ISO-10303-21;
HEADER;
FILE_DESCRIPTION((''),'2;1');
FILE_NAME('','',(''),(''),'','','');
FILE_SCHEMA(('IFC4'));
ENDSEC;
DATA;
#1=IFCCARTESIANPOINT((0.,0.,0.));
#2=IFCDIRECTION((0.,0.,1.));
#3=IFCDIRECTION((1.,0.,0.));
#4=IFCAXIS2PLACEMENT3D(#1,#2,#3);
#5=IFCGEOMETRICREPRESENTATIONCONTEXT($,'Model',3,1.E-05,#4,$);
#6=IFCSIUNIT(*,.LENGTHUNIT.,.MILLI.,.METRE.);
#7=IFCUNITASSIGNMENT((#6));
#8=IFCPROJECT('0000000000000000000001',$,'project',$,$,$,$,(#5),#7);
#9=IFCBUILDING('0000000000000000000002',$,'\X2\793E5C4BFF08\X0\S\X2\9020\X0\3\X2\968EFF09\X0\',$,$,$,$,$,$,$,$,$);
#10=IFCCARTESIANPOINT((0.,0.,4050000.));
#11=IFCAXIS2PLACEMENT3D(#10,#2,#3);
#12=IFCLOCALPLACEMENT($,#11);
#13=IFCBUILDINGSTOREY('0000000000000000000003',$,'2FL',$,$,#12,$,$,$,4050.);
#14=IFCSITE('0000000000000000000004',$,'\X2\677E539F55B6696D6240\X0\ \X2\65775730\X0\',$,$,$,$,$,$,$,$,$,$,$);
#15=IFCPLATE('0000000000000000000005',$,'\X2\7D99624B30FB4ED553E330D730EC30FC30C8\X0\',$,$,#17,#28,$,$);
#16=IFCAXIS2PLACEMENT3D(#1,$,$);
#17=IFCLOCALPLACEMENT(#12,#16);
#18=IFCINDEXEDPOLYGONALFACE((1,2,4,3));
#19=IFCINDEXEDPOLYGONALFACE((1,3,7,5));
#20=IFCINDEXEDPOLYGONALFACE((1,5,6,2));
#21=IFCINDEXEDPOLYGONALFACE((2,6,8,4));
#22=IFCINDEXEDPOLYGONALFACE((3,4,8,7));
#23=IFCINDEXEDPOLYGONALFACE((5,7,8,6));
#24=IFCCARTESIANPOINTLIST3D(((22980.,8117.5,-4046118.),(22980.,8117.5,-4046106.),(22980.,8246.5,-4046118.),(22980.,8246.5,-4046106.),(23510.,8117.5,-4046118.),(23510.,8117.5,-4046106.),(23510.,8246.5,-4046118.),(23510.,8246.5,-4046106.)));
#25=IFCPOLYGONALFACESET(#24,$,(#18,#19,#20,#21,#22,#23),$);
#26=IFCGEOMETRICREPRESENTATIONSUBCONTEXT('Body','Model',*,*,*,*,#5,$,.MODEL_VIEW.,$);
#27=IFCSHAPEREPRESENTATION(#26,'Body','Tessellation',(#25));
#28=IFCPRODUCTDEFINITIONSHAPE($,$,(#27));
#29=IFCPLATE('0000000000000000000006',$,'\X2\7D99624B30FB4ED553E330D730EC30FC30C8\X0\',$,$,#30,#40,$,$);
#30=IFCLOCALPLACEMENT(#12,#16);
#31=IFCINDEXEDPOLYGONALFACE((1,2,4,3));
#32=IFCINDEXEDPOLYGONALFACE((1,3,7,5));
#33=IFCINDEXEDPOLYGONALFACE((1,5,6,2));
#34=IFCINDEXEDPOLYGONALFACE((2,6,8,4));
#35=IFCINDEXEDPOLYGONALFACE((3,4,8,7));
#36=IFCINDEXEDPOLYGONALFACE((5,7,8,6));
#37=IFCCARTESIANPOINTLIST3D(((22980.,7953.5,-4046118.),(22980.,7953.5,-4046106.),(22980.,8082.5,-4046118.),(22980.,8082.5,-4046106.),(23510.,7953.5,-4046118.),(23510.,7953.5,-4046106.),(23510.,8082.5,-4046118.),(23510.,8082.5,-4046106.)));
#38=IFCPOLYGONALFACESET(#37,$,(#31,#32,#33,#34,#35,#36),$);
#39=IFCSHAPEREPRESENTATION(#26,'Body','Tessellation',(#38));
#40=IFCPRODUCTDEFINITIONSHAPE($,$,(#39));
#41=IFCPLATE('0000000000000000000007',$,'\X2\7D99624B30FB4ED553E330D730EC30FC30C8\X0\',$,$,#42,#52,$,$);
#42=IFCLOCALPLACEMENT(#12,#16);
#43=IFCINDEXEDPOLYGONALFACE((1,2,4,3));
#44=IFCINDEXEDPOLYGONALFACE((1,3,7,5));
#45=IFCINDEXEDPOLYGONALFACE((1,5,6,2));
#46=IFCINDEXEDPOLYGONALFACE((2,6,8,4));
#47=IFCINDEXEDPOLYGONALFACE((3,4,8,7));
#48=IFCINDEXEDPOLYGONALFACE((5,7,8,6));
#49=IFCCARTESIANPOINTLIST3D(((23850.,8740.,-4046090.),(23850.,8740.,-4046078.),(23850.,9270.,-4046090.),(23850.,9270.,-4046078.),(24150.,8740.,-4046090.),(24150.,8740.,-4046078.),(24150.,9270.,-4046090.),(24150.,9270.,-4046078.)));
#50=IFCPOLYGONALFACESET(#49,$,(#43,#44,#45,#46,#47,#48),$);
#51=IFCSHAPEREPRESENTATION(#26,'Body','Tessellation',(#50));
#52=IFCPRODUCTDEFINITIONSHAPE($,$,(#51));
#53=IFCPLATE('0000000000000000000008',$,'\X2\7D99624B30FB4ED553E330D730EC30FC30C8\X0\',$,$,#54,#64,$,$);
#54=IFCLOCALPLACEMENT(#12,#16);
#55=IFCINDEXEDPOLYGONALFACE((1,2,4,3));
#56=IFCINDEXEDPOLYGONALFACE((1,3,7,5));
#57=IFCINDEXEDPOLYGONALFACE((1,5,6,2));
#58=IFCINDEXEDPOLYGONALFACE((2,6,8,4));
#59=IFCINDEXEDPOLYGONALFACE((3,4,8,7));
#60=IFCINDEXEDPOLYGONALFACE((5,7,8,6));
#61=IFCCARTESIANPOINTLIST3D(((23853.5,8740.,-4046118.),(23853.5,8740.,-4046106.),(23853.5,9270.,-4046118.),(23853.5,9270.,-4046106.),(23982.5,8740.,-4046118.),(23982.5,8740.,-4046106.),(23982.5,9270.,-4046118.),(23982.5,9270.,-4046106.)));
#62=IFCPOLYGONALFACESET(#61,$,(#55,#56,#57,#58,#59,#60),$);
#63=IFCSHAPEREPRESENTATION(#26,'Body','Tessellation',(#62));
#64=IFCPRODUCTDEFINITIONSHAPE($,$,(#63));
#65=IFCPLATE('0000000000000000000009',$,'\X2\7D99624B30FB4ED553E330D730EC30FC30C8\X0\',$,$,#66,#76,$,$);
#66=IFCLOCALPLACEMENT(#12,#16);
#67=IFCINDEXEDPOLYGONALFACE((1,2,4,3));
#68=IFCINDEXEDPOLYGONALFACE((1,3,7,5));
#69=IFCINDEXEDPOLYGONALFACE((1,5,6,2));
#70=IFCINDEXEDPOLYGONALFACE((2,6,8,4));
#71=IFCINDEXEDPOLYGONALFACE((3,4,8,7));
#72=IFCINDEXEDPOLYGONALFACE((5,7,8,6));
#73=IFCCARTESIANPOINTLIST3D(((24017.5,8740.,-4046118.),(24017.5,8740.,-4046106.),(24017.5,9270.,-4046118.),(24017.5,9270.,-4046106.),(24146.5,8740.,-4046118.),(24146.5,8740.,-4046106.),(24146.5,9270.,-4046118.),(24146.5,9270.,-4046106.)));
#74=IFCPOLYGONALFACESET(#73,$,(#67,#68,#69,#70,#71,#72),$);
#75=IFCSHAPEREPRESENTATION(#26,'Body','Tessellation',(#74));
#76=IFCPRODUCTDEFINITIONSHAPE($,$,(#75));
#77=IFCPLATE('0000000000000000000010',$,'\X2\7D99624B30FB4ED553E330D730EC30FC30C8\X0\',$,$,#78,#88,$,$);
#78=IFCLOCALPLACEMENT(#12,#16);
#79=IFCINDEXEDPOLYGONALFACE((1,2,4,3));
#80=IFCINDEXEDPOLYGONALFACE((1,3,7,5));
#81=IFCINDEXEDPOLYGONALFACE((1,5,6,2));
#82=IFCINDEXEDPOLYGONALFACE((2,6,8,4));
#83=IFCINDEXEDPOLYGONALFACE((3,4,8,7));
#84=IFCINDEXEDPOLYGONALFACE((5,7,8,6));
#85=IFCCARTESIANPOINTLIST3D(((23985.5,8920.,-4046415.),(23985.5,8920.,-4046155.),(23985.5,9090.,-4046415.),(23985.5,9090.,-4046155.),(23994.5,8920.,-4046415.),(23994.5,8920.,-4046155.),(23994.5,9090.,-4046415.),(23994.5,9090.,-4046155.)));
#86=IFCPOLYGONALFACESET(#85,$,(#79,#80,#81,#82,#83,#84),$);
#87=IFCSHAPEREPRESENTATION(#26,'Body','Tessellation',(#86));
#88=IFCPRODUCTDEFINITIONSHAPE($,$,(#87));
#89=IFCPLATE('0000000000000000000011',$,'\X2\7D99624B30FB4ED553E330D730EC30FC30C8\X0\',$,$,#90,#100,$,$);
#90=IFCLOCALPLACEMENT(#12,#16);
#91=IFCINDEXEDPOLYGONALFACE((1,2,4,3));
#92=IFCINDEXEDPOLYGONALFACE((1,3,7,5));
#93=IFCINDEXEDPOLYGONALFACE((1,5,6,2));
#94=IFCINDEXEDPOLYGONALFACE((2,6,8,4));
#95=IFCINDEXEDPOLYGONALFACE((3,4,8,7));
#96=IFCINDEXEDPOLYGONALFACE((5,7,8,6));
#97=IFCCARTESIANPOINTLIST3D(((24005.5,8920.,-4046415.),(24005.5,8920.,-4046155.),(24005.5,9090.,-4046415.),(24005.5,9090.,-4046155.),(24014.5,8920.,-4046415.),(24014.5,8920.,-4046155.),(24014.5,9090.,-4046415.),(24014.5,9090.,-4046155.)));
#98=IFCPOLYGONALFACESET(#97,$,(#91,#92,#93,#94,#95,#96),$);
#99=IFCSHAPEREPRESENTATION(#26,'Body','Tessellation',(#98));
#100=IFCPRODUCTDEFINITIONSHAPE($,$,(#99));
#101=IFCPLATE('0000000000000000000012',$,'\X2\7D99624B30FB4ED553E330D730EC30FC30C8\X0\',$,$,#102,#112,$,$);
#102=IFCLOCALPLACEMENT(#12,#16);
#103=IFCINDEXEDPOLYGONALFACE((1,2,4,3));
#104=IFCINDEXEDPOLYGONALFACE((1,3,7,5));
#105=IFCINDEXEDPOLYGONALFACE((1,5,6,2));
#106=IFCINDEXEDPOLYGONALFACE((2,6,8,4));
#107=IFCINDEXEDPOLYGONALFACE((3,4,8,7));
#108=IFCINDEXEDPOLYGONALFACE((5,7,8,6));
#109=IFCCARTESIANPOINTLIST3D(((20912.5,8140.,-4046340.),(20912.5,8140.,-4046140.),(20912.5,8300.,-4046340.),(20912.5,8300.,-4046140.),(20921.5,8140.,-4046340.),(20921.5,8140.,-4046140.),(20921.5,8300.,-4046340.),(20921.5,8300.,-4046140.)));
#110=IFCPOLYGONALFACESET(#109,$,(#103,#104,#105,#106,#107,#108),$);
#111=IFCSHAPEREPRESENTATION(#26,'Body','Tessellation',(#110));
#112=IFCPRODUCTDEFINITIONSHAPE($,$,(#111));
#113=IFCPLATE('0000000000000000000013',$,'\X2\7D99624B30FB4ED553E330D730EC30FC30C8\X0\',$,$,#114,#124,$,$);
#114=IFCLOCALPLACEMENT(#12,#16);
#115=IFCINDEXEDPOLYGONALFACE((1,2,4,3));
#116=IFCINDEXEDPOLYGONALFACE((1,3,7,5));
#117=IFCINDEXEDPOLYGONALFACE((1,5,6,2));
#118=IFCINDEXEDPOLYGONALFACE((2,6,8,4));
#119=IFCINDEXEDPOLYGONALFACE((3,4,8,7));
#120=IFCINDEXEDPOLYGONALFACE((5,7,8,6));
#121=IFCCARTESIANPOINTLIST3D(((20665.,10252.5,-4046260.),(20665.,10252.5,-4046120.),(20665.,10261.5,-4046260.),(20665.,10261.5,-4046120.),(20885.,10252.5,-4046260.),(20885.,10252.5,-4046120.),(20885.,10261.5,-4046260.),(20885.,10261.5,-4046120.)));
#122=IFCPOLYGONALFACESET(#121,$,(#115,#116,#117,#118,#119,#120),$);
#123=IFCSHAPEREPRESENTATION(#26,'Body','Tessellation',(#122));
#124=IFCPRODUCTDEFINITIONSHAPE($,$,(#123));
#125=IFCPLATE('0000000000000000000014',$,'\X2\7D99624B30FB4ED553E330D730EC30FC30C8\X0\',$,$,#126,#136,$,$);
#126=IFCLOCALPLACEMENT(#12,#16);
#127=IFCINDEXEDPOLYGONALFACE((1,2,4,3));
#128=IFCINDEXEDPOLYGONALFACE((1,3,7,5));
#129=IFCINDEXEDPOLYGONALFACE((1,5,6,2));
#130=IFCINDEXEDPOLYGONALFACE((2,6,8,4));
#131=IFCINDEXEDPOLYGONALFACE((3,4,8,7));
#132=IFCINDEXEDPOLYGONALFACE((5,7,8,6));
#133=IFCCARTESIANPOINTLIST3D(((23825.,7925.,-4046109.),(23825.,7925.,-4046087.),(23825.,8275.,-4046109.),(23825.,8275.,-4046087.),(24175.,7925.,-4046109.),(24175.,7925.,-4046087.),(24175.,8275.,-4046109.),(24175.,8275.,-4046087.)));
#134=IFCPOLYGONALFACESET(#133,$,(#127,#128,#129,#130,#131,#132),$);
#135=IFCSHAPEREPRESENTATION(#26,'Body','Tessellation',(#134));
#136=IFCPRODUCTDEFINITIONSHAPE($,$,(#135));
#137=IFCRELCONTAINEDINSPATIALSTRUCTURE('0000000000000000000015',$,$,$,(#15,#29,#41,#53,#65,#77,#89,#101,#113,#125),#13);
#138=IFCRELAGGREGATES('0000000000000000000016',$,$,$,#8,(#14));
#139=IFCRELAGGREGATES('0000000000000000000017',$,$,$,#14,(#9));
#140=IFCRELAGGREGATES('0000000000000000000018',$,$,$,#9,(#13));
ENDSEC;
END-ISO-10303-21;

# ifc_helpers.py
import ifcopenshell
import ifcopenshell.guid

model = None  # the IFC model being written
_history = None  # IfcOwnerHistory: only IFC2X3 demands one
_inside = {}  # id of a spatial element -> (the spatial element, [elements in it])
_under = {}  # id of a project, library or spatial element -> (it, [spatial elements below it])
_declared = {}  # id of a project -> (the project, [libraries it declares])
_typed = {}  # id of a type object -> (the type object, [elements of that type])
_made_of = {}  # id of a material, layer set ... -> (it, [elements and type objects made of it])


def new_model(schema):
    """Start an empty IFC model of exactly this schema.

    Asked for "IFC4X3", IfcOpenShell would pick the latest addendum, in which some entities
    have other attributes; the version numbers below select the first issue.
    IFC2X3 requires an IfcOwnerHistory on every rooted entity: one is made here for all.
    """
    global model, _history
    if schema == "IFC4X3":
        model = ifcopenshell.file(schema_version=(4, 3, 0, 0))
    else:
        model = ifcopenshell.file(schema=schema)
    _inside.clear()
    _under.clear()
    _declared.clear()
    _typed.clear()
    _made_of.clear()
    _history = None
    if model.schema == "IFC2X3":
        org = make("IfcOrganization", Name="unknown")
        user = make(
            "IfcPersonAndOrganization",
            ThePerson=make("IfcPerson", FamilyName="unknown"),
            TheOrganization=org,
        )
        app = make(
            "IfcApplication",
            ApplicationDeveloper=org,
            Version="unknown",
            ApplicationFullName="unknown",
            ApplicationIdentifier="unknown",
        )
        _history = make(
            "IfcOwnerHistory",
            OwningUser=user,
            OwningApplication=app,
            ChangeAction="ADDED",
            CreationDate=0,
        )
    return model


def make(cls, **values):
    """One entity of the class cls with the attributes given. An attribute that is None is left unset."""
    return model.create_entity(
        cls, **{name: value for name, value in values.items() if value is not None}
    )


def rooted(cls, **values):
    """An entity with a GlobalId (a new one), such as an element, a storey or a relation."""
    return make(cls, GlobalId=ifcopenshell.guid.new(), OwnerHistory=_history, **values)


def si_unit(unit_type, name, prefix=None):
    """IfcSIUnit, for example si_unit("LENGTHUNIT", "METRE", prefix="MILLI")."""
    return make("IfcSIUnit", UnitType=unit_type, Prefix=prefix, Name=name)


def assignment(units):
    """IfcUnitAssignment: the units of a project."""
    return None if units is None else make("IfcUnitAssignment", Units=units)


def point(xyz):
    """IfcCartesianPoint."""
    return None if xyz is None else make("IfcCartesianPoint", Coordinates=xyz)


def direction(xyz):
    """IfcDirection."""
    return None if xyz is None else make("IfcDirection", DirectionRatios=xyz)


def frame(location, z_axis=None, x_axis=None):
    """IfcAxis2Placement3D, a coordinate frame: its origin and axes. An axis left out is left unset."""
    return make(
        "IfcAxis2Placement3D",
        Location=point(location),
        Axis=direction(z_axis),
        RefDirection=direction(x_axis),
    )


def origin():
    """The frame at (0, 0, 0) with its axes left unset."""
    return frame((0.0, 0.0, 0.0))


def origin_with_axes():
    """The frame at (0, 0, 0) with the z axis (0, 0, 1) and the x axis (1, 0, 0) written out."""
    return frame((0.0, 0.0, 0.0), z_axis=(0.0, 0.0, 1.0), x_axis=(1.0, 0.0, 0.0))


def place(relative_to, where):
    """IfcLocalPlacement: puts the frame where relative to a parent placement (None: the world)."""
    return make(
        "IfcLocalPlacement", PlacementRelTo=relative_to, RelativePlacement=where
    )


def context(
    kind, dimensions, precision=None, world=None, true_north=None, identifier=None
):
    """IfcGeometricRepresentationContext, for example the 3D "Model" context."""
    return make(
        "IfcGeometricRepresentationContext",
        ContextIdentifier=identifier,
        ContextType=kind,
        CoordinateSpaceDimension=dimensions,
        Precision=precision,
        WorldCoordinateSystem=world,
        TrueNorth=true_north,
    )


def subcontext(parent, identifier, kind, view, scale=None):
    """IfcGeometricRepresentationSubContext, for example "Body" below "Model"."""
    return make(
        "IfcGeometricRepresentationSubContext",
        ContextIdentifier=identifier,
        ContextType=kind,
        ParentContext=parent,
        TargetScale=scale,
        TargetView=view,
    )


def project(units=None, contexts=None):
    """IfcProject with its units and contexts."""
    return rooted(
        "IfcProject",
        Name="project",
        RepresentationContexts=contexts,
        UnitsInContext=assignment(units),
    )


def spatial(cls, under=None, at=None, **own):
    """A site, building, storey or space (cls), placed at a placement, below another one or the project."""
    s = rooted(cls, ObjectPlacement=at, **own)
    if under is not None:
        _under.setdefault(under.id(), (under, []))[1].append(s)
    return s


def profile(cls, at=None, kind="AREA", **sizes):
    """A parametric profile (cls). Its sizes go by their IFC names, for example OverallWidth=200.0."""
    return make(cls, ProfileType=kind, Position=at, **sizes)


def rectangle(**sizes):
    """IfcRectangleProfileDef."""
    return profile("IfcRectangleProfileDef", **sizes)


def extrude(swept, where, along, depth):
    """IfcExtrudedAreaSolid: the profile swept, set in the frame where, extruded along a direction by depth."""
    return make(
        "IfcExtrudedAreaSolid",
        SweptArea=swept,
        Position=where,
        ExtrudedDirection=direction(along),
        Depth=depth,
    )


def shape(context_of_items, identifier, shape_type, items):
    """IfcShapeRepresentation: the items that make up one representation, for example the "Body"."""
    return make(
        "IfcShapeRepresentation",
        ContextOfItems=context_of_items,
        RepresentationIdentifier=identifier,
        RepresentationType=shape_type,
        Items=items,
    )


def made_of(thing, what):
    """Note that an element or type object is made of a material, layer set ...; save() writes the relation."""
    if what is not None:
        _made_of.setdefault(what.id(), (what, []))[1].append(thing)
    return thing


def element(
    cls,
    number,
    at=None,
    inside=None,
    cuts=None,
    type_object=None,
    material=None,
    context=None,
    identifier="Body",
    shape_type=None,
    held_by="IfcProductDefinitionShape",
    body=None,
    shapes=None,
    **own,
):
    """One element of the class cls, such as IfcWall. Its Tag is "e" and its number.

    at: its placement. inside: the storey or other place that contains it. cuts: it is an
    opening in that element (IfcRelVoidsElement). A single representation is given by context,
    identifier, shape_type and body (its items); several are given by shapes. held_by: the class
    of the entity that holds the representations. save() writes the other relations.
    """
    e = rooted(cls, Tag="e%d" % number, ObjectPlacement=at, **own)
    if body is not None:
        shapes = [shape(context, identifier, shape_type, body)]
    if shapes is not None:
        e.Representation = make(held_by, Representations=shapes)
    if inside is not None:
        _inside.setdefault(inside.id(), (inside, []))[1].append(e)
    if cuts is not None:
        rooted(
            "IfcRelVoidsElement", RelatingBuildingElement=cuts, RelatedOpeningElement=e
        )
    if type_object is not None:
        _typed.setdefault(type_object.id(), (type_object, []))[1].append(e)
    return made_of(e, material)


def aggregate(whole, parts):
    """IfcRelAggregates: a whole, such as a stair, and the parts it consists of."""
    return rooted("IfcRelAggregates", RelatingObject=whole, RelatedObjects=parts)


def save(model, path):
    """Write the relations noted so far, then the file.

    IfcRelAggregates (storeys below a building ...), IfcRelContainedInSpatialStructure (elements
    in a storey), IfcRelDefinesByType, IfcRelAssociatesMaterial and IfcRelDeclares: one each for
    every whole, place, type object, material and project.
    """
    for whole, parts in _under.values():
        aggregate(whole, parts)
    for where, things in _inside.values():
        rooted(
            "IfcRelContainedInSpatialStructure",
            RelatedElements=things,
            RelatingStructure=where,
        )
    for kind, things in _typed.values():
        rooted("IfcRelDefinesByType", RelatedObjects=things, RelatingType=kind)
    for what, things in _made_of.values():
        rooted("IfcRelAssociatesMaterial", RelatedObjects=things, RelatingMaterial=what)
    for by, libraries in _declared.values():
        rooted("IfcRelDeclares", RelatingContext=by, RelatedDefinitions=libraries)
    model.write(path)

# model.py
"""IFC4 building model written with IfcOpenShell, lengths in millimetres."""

from ifc_helpers import new_model, si_unit, frame, origin, origin_with_axes, place, context, subcontext, project, spatial, rectangle, extrude, element, save


model = new_model("IFC4")

# Units and contexts
model_context = context("Model", 3, precision=1e-05, world=origin_with_axes())
body_context = subcontext(model_context, "Body", "Model", "MODEL_VIEW")
ifc_project = project(units=[si_unit("LENGTHUNIT", "METRE", prefix="MILLI")], contexts=[model_context])

# Site, building, storey
site = spatial("IfcSite", under=ifc_project, Name="松原営業所 敷地")
building = spatial("IfcBuilding", under=site, Name="社屋（S造3階）")
storey_placement = place(None, frame((0.0, 0.0, 4050000.0), z_axis=(0.0, 0.0, 1.0), x_axis=(1.0, 0.0, 0.0)))
storey = spatial("IfcBuildingStorey", under=building, at=storey_placement, Name="2FL", Elevation=4050.0)

# Plates
for number, where, z_axis, x_axis, name in (
    (1, (22980.0, 8182.0, -4046112.0), (1.0, 0.0, 0.0), (0.0, 1.0, 0.0), "継手・仕口プレート"),
    (2, (22980.0, 8018.0, -4046112.0), (1.0, 0.0, 0.0), (0.0, 1.0, 0.0), "継手・仕口プレート"),
):
    element("IfcPlate", number, at=place(storey_placement, frame(where, z_axis=z_axis, x_axis=x_axis)), inside=storey, Name=name, context=body_context, shape_type="SweptSolid", body=[
        extrude(rectangle(XDim=129.0, YDim=12.0), origin(), (0.0, 0.0, 1.0), 530.0),
    ])
plate_1_placement = place(storey_placement, frame((24000.0, 8740.0, -4046084.0), z_axis=(0.0, 1.0, 0.0), x_axis=(-1.0, 0.0, 0.0)))
element("IfcPlate", 3, at=plate_1_placement, inside=storey, Name="継手・仕口プレート", context=body_context, shape_type="SweptSolid", body=[
    extrude(rectangle(XDim=300.0, YDim=12.0), origin(), (0.0, 0.0, 1.0), 530.0),
])
for number, where, z_axis, x_axis, name in (
    (4, (23918.0, 8740.0, -4046112.0), (0.0, 1.0, 0.0), (-1.0, 0.0, 0.0), "継手・仕口プレート"),
    (5, (24082.0, 8740.0, -4046112.0), (0.0, 1.0, 0.0), (-1.0, 0.0, 0.0), "継手・仕口プレート"),
):
    element("IfcPlate", number, at=place(storey_placement, frame(where, z_axis=z_axis, x_axis=x_axis)), inside=storey, Name=name, context=body_context, shape_type="SweptSolid", body=[
        extrude(rectangle(XDim=129.0, YDim=12.0), origin(), (0.0, 0.0, 1.0), 530.0),
    ])
for number, where, z_axis, x_axis, name in (
    (6, (23990.0, 8920.0, -4046285.0), (0.0, 1.0, 0.0), (-1.0, 0.0, 0.0), "継手・仕口プレート"),
    (7, (24010.0, 8920.0, -4046285.0), (0.0, 1.0, 0.0), (-1.0, 0.0, 0.0), "継手・仕口プレート"),
):
    element("IfcPlate", number, at=place(storey_placement, frame(where, z_axis=z_axis, x_axis=x_axis)), inside=storey, Name=name, context=body_context, shape_type="SweptSolid", body=[
        extrude(rectangle(XDim=9.0, YDim=260.0), origin(), (0.0, 0.0, 1.0), 170.0),
    ])
plate_2_placement = place(storey_placement, frame((20917.0, 8140.0, -4046240.0), z_axis=(0.0, 1.0, 0.0), x_axis=(-1.0, 0.0, 0.0)))
element("IfcPlate", 8, at=plate_2_placement, inside=storey, Name="継手・仕口プレート", context=body_context, shape_type="SweptSolid", body=[
    extrude(rectangle(XDim=9.0, YDim=200.0), origin(), (0.0, 0.0, 1.0), 160.0),
])
plate_3_placement = place(storey_placement, frame((20665.0, 10257.0, -4046190.0), z_axis=(1.0, 0.0, 0.0), x_axis=(0.0, 1.0, 0.0)))
element("IfcPlate", 9, at=plate_3_placement, inside=storey, Name="継手・仕口プレート", context=body_context, shape_type="SweptSolid", body=[
    extrude(rectangle(XDim=9.0, YDim=140.0), origin(), (0.0, 0.0, 1.0), 220.0),
])
plate_4_placement = place(storey_placement, frame((23825.0, 8100.0, -4046098.0), z_axis=(1.0, 0.0, 0.0), x_axis=(0.0, 1.0, 0.0)))
element("IfcPlate", 10, at=plate_4_placement, inside=storey, Name="継手・仕口プレート", context=body_context, shape_type="SweptSolid", body=[
    extrude(rectangle(XDim=350.0, YDim=22.0), origin(), (0.0, 0.0, 1.0), 350.0),
])

save(model, "model.ifc")
